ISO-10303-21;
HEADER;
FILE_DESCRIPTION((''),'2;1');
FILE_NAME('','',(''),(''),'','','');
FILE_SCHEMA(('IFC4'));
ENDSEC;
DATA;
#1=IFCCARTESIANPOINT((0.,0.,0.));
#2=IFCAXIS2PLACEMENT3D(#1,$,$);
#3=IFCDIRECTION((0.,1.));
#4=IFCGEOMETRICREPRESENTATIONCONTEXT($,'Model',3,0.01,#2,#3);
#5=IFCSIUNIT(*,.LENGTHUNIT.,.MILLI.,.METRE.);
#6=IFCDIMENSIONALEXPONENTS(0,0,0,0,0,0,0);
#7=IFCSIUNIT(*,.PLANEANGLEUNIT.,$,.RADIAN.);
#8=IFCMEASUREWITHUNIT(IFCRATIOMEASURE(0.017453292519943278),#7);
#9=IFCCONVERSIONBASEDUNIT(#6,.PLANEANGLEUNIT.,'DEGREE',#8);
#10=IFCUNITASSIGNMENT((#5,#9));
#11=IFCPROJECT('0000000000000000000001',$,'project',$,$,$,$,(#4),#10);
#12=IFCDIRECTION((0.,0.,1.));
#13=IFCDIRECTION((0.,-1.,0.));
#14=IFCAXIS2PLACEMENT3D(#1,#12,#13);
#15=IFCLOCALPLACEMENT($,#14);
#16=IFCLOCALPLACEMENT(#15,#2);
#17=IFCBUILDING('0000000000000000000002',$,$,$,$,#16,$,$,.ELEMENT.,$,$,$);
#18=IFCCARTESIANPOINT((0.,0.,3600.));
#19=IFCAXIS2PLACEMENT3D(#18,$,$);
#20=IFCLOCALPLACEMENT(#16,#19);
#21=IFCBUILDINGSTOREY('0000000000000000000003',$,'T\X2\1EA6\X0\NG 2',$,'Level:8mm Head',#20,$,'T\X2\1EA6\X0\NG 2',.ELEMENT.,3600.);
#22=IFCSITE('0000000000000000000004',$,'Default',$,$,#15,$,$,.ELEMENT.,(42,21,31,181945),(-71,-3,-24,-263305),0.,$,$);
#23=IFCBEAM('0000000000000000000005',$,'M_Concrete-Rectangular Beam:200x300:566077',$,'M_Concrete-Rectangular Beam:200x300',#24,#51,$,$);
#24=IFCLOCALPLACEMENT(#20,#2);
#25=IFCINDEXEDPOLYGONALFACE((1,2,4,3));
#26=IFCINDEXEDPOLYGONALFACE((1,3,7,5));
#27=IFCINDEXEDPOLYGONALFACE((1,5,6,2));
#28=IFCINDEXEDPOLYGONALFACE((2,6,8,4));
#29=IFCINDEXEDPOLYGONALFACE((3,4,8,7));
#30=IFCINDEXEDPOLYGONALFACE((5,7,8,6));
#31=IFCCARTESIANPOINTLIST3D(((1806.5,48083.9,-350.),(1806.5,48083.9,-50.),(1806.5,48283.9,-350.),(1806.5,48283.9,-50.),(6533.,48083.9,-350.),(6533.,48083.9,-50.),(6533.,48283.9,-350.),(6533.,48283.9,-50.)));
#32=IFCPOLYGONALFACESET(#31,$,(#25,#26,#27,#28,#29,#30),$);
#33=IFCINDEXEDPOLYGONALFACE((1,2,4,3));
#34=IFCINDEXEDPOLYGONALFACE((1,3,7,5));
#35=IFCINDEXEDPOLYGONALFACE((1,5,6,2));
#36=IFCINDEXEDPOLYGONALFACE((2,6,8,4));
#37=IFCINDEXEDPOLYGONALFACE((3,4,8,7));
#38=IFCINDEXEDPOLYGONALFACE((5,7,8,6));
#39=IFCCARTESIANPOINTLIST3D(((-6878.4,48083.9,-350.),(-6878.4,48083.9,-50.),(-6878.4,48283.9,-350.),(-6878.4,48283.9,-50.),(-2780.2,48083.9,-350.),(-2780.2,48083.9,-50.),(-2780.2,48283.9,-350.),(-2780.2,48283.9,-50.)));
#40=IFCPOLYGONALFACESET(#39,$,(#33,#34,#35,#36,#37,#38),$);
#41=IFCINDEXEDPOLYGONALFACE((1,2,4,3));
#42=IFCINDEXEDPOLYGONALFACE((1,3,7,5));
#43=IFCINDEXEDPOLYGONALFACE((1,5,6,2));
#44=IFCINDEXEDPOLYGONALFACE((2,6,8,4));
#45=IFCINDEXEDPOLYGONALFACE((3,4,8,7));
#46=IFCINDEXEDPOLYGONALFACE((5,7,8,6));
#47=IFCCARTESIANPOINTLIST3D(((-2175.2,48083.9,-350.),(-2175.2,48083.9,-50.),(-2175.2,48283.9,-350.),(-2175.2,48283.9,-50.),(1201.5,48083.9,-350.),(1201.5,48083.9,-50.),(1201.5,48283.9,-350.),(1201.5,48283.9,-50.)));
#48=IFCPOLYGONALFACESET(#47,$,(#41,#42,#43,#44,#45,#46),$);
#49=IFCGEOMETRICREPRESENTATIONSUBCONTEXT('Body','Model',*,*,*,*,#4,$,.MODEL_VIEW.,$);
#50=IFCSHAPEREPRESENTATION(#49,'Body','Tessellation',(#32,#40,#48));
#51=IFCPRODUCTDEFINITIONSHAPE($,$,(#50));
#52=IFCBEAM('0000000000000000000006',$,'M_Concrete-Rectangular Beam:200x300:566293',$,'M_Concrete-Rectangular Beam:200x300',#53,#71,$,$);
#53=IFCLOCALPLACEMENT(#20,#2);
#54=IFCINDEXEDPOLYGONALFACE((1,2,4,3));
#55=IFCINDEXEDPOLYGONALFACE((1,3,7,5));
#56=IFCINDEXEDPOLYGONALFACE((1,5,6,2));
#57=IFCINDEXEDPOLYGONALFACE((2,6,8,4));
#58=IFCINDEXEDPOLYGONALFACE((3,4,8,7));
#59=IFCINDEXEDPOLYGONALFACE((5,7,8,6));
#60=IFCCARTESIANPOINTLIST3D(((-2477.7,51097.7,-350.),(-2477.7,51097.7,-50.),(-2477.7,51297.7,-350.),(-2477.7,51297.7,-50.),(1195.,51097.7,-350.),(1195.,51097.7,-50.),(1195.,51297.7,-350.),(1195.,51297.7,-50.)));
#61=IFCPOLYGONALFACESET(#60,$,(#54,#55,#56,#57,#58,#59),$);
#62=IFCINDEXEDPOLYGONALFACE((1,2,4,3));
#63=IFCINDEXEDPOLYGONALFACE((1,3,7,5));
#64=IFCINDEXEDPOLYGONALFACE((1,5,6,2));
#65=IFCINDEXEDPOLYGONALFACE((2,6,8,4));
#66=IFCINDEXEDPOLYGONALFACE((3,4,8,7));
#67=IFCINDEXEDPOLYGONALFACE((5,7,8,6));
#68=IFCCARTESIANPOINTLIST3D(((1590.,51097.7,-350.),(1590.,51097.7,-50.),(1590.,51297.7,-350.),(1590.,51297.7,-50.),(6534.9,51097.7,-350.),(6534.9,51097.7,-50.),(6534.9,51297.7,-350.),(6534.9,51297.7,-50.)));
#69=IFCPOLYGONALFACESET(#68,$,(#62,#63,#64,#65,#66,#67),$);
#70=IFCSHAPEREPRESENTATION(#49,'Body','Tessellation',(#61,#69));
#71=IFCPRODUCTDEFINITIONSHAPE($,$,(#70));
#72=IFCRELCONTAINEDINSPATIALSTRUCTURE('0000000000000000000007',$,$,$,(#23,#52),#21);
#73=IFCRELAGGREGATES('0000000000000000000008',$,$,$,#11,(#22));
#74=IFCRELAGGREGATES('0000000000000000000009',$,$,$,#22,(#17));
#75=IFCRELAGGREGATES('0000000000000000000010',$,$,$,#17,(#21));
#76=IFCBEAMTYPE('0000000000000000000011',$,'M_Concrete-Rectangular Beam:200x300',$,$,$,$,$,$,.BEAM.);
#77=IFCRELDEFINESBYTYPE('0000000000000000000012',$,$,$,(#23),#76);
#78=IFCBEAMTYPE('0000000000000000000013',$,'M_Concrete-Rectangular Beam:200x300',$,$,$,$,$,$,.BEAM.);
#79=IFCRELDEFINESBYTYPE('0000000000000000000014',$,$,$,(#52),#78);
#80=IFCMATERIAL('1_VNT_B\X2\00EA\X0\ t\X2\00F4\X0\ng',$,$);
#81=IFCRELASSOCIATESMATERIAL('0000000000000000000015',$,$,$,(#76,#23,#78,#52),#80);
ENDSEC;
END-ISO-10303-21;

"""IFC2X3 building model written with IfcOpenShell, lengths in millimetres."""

from ifc_helpers import new_model, entity, si_unit, converted_unit, direction, frame, frame_2d, origin, origin_2d_with_axis, place, context, subcontext, project, spatial, rectangle, extrude, source, transform, mapped, material, type_object, type_shapes, element, save


model = new_model("IFC2X3")

# Units and contexts
model_context = context("Model", 3, precision=0.01, world=origin(), true_north=direction((0.0, 1.0)))
body_context = subcontext(model_context, "Body", "Model", "MODEL_VIEW")
ifc_project = project(units=[si_unit("LENGTHUNIT", "METRE", prefix="MILLI"), converted_unit("PLANEANGLEUNIT", "DEGREE", entity("IfcRatioMeasure", 0.017453292519943278), si_unit("PLANEANGLEUNIT", "RADIAN"), dimensions=[0, 0, 0, 0, 0, 0, 0])], contexts=[model_context])

# Site, building, storey
site_placement = place(None, frame((0.0, 0.0, 0.0), z_axis=(0.0, 0.0, 1.0), x_axis=(0.0, -1.0, 0.0)))
site = spatial("IfcSite", under=ifc_project, at=site_placement, Name="Default", CompositionType="ELEMENT", RefLatitude=(42, 21, 31, 181945), RefLongitude=(-71, -3, -24, -263305), RefElevation=0.0)
building_placement = place(site_placement, origin())
building = spatial("IfcBuilding", under=site, at=building_placement, CompositionType="ELEMENT")
storey_placement = place(building_placement, frame((0.0, 0.0, 3600.0)))
storey = spatial("IfcBuildingStorey", under=building, at=storey_placement, Name="TẦNG 2", ObjectType="Level:8mm Head", LongName="TẦNG 2", CompositionType="ELEMENT", Elevation=3600.0)

# Beams
ifc_material = material(Name="1_VNT_Bê tông")
beam_type_1 = type_object("IfcBeamType", Name="M_Concrete-Rectangular Beam:200x300", PredefinedType="BEAM", material=ifc_material)
shared_shape_1 = source(origin(), body_context, "Body", "SweptSolid", [
    extrude(rectangle(XDim=300.0, YDim=200.0, at=origin_2d_with_axis()), frame((1806.5, 48183.9, 3400.0), z_axis=(1.0, 0.0, 0.0), x_axis=(0.0, 0.0, -1.0)), (0.0, 0.0, 1.0), 4726.6),
    extrude(rectangle(XDim=300.0, YDim=200.0, at=frame_2d((0.0, 0.0), x_axis=(1.0, 0.0))), frame((-6878.4, 48183.9, 3400.0), z_axis=(1.0, 0.0, 0.0), x_axis=(0.0, 0.0, -1.0)), (0.0, 0.0, 1.0), 4098.3),
    extrude(rectangle(XDim=300.0, YDim=200.0, at=origin_2d_with_axis()), frame((-2175.2, 48183.9, 3400.0), z_axis=(1.0, 0.0, 0.0), x_axis=(0.0, 0.0, -1.0)), (0.0, 0.0, 1.0), 3376.7),
])
type_shapes(beam_type_1, [shared_shape_1])
beam_1_placement = place(storey_placement, frame((0.0, 0.0, -3600.0)))
element("IfcBeam", 1, at=beam_1_placement, inside=storey, type_object=beam_type_1, material=ifc_material, Name="M_Concrete-Rectangular Beam:200x300:566077", ObjectType="M_Concrete-Rectangular Beam:200x300", context=body_context, shape_type="MappedRepresentation", body=[
    mapped(shared_shape_1, transform((0.0, 0.0, 0.0), scale=1.0)),
])
beam_type_2 = type_object("IfcBeamType", Name="M_Concrete-Rectangular Beam:200x300", PredefinedType="BEAM", material=ifc_material)
shared_shape_2 = source(origin(), body_context, "Body", "SweptSolid", [
    extrude(rectangle(XDim=300.0, YDim=200.0, at=origin_2d_with_axis()), frame((1195.0, 51197.7, 3400.0), z_axis=(-1.0, 0.0, 0.0), x_axis=(0.0, 0.0, -1.0)), (0.0, 0.0, 1.0), 3672.7),
    extrude(rectangle(XDim=300.0, YDim=200.0, at=origin_2d_with_axis()), frame((6534.9, 51197.7, 3400.0), z_axis=(-1.0, 0.0, 0.0), x_axis=(0.0, 0.0, -1.0)), (0.0, 0.0, 1.0), 4944.9),
])
type_shapes(beam_type_2, [shared_shape_2])
beam_2_placement = place(storey_placement, frame((0.0, 0.0, -3600.0)))
element("IfcBeam", 2, at=beam_2_placement, inside=storey, type_object=beam_type_2, material=ifc_material, Name="M_Concrete-Rectangular Beam:200x300:566293", ObjectType="M_Concrete-Rectangular Beam:200x300", context=body_context, shape_type="MappedRepresentation", body=[
    mapped(shared_shape_2, transform((0.0, 0.0, 0.0), scale=1.0)),
])

save(model, "model.ifc")
